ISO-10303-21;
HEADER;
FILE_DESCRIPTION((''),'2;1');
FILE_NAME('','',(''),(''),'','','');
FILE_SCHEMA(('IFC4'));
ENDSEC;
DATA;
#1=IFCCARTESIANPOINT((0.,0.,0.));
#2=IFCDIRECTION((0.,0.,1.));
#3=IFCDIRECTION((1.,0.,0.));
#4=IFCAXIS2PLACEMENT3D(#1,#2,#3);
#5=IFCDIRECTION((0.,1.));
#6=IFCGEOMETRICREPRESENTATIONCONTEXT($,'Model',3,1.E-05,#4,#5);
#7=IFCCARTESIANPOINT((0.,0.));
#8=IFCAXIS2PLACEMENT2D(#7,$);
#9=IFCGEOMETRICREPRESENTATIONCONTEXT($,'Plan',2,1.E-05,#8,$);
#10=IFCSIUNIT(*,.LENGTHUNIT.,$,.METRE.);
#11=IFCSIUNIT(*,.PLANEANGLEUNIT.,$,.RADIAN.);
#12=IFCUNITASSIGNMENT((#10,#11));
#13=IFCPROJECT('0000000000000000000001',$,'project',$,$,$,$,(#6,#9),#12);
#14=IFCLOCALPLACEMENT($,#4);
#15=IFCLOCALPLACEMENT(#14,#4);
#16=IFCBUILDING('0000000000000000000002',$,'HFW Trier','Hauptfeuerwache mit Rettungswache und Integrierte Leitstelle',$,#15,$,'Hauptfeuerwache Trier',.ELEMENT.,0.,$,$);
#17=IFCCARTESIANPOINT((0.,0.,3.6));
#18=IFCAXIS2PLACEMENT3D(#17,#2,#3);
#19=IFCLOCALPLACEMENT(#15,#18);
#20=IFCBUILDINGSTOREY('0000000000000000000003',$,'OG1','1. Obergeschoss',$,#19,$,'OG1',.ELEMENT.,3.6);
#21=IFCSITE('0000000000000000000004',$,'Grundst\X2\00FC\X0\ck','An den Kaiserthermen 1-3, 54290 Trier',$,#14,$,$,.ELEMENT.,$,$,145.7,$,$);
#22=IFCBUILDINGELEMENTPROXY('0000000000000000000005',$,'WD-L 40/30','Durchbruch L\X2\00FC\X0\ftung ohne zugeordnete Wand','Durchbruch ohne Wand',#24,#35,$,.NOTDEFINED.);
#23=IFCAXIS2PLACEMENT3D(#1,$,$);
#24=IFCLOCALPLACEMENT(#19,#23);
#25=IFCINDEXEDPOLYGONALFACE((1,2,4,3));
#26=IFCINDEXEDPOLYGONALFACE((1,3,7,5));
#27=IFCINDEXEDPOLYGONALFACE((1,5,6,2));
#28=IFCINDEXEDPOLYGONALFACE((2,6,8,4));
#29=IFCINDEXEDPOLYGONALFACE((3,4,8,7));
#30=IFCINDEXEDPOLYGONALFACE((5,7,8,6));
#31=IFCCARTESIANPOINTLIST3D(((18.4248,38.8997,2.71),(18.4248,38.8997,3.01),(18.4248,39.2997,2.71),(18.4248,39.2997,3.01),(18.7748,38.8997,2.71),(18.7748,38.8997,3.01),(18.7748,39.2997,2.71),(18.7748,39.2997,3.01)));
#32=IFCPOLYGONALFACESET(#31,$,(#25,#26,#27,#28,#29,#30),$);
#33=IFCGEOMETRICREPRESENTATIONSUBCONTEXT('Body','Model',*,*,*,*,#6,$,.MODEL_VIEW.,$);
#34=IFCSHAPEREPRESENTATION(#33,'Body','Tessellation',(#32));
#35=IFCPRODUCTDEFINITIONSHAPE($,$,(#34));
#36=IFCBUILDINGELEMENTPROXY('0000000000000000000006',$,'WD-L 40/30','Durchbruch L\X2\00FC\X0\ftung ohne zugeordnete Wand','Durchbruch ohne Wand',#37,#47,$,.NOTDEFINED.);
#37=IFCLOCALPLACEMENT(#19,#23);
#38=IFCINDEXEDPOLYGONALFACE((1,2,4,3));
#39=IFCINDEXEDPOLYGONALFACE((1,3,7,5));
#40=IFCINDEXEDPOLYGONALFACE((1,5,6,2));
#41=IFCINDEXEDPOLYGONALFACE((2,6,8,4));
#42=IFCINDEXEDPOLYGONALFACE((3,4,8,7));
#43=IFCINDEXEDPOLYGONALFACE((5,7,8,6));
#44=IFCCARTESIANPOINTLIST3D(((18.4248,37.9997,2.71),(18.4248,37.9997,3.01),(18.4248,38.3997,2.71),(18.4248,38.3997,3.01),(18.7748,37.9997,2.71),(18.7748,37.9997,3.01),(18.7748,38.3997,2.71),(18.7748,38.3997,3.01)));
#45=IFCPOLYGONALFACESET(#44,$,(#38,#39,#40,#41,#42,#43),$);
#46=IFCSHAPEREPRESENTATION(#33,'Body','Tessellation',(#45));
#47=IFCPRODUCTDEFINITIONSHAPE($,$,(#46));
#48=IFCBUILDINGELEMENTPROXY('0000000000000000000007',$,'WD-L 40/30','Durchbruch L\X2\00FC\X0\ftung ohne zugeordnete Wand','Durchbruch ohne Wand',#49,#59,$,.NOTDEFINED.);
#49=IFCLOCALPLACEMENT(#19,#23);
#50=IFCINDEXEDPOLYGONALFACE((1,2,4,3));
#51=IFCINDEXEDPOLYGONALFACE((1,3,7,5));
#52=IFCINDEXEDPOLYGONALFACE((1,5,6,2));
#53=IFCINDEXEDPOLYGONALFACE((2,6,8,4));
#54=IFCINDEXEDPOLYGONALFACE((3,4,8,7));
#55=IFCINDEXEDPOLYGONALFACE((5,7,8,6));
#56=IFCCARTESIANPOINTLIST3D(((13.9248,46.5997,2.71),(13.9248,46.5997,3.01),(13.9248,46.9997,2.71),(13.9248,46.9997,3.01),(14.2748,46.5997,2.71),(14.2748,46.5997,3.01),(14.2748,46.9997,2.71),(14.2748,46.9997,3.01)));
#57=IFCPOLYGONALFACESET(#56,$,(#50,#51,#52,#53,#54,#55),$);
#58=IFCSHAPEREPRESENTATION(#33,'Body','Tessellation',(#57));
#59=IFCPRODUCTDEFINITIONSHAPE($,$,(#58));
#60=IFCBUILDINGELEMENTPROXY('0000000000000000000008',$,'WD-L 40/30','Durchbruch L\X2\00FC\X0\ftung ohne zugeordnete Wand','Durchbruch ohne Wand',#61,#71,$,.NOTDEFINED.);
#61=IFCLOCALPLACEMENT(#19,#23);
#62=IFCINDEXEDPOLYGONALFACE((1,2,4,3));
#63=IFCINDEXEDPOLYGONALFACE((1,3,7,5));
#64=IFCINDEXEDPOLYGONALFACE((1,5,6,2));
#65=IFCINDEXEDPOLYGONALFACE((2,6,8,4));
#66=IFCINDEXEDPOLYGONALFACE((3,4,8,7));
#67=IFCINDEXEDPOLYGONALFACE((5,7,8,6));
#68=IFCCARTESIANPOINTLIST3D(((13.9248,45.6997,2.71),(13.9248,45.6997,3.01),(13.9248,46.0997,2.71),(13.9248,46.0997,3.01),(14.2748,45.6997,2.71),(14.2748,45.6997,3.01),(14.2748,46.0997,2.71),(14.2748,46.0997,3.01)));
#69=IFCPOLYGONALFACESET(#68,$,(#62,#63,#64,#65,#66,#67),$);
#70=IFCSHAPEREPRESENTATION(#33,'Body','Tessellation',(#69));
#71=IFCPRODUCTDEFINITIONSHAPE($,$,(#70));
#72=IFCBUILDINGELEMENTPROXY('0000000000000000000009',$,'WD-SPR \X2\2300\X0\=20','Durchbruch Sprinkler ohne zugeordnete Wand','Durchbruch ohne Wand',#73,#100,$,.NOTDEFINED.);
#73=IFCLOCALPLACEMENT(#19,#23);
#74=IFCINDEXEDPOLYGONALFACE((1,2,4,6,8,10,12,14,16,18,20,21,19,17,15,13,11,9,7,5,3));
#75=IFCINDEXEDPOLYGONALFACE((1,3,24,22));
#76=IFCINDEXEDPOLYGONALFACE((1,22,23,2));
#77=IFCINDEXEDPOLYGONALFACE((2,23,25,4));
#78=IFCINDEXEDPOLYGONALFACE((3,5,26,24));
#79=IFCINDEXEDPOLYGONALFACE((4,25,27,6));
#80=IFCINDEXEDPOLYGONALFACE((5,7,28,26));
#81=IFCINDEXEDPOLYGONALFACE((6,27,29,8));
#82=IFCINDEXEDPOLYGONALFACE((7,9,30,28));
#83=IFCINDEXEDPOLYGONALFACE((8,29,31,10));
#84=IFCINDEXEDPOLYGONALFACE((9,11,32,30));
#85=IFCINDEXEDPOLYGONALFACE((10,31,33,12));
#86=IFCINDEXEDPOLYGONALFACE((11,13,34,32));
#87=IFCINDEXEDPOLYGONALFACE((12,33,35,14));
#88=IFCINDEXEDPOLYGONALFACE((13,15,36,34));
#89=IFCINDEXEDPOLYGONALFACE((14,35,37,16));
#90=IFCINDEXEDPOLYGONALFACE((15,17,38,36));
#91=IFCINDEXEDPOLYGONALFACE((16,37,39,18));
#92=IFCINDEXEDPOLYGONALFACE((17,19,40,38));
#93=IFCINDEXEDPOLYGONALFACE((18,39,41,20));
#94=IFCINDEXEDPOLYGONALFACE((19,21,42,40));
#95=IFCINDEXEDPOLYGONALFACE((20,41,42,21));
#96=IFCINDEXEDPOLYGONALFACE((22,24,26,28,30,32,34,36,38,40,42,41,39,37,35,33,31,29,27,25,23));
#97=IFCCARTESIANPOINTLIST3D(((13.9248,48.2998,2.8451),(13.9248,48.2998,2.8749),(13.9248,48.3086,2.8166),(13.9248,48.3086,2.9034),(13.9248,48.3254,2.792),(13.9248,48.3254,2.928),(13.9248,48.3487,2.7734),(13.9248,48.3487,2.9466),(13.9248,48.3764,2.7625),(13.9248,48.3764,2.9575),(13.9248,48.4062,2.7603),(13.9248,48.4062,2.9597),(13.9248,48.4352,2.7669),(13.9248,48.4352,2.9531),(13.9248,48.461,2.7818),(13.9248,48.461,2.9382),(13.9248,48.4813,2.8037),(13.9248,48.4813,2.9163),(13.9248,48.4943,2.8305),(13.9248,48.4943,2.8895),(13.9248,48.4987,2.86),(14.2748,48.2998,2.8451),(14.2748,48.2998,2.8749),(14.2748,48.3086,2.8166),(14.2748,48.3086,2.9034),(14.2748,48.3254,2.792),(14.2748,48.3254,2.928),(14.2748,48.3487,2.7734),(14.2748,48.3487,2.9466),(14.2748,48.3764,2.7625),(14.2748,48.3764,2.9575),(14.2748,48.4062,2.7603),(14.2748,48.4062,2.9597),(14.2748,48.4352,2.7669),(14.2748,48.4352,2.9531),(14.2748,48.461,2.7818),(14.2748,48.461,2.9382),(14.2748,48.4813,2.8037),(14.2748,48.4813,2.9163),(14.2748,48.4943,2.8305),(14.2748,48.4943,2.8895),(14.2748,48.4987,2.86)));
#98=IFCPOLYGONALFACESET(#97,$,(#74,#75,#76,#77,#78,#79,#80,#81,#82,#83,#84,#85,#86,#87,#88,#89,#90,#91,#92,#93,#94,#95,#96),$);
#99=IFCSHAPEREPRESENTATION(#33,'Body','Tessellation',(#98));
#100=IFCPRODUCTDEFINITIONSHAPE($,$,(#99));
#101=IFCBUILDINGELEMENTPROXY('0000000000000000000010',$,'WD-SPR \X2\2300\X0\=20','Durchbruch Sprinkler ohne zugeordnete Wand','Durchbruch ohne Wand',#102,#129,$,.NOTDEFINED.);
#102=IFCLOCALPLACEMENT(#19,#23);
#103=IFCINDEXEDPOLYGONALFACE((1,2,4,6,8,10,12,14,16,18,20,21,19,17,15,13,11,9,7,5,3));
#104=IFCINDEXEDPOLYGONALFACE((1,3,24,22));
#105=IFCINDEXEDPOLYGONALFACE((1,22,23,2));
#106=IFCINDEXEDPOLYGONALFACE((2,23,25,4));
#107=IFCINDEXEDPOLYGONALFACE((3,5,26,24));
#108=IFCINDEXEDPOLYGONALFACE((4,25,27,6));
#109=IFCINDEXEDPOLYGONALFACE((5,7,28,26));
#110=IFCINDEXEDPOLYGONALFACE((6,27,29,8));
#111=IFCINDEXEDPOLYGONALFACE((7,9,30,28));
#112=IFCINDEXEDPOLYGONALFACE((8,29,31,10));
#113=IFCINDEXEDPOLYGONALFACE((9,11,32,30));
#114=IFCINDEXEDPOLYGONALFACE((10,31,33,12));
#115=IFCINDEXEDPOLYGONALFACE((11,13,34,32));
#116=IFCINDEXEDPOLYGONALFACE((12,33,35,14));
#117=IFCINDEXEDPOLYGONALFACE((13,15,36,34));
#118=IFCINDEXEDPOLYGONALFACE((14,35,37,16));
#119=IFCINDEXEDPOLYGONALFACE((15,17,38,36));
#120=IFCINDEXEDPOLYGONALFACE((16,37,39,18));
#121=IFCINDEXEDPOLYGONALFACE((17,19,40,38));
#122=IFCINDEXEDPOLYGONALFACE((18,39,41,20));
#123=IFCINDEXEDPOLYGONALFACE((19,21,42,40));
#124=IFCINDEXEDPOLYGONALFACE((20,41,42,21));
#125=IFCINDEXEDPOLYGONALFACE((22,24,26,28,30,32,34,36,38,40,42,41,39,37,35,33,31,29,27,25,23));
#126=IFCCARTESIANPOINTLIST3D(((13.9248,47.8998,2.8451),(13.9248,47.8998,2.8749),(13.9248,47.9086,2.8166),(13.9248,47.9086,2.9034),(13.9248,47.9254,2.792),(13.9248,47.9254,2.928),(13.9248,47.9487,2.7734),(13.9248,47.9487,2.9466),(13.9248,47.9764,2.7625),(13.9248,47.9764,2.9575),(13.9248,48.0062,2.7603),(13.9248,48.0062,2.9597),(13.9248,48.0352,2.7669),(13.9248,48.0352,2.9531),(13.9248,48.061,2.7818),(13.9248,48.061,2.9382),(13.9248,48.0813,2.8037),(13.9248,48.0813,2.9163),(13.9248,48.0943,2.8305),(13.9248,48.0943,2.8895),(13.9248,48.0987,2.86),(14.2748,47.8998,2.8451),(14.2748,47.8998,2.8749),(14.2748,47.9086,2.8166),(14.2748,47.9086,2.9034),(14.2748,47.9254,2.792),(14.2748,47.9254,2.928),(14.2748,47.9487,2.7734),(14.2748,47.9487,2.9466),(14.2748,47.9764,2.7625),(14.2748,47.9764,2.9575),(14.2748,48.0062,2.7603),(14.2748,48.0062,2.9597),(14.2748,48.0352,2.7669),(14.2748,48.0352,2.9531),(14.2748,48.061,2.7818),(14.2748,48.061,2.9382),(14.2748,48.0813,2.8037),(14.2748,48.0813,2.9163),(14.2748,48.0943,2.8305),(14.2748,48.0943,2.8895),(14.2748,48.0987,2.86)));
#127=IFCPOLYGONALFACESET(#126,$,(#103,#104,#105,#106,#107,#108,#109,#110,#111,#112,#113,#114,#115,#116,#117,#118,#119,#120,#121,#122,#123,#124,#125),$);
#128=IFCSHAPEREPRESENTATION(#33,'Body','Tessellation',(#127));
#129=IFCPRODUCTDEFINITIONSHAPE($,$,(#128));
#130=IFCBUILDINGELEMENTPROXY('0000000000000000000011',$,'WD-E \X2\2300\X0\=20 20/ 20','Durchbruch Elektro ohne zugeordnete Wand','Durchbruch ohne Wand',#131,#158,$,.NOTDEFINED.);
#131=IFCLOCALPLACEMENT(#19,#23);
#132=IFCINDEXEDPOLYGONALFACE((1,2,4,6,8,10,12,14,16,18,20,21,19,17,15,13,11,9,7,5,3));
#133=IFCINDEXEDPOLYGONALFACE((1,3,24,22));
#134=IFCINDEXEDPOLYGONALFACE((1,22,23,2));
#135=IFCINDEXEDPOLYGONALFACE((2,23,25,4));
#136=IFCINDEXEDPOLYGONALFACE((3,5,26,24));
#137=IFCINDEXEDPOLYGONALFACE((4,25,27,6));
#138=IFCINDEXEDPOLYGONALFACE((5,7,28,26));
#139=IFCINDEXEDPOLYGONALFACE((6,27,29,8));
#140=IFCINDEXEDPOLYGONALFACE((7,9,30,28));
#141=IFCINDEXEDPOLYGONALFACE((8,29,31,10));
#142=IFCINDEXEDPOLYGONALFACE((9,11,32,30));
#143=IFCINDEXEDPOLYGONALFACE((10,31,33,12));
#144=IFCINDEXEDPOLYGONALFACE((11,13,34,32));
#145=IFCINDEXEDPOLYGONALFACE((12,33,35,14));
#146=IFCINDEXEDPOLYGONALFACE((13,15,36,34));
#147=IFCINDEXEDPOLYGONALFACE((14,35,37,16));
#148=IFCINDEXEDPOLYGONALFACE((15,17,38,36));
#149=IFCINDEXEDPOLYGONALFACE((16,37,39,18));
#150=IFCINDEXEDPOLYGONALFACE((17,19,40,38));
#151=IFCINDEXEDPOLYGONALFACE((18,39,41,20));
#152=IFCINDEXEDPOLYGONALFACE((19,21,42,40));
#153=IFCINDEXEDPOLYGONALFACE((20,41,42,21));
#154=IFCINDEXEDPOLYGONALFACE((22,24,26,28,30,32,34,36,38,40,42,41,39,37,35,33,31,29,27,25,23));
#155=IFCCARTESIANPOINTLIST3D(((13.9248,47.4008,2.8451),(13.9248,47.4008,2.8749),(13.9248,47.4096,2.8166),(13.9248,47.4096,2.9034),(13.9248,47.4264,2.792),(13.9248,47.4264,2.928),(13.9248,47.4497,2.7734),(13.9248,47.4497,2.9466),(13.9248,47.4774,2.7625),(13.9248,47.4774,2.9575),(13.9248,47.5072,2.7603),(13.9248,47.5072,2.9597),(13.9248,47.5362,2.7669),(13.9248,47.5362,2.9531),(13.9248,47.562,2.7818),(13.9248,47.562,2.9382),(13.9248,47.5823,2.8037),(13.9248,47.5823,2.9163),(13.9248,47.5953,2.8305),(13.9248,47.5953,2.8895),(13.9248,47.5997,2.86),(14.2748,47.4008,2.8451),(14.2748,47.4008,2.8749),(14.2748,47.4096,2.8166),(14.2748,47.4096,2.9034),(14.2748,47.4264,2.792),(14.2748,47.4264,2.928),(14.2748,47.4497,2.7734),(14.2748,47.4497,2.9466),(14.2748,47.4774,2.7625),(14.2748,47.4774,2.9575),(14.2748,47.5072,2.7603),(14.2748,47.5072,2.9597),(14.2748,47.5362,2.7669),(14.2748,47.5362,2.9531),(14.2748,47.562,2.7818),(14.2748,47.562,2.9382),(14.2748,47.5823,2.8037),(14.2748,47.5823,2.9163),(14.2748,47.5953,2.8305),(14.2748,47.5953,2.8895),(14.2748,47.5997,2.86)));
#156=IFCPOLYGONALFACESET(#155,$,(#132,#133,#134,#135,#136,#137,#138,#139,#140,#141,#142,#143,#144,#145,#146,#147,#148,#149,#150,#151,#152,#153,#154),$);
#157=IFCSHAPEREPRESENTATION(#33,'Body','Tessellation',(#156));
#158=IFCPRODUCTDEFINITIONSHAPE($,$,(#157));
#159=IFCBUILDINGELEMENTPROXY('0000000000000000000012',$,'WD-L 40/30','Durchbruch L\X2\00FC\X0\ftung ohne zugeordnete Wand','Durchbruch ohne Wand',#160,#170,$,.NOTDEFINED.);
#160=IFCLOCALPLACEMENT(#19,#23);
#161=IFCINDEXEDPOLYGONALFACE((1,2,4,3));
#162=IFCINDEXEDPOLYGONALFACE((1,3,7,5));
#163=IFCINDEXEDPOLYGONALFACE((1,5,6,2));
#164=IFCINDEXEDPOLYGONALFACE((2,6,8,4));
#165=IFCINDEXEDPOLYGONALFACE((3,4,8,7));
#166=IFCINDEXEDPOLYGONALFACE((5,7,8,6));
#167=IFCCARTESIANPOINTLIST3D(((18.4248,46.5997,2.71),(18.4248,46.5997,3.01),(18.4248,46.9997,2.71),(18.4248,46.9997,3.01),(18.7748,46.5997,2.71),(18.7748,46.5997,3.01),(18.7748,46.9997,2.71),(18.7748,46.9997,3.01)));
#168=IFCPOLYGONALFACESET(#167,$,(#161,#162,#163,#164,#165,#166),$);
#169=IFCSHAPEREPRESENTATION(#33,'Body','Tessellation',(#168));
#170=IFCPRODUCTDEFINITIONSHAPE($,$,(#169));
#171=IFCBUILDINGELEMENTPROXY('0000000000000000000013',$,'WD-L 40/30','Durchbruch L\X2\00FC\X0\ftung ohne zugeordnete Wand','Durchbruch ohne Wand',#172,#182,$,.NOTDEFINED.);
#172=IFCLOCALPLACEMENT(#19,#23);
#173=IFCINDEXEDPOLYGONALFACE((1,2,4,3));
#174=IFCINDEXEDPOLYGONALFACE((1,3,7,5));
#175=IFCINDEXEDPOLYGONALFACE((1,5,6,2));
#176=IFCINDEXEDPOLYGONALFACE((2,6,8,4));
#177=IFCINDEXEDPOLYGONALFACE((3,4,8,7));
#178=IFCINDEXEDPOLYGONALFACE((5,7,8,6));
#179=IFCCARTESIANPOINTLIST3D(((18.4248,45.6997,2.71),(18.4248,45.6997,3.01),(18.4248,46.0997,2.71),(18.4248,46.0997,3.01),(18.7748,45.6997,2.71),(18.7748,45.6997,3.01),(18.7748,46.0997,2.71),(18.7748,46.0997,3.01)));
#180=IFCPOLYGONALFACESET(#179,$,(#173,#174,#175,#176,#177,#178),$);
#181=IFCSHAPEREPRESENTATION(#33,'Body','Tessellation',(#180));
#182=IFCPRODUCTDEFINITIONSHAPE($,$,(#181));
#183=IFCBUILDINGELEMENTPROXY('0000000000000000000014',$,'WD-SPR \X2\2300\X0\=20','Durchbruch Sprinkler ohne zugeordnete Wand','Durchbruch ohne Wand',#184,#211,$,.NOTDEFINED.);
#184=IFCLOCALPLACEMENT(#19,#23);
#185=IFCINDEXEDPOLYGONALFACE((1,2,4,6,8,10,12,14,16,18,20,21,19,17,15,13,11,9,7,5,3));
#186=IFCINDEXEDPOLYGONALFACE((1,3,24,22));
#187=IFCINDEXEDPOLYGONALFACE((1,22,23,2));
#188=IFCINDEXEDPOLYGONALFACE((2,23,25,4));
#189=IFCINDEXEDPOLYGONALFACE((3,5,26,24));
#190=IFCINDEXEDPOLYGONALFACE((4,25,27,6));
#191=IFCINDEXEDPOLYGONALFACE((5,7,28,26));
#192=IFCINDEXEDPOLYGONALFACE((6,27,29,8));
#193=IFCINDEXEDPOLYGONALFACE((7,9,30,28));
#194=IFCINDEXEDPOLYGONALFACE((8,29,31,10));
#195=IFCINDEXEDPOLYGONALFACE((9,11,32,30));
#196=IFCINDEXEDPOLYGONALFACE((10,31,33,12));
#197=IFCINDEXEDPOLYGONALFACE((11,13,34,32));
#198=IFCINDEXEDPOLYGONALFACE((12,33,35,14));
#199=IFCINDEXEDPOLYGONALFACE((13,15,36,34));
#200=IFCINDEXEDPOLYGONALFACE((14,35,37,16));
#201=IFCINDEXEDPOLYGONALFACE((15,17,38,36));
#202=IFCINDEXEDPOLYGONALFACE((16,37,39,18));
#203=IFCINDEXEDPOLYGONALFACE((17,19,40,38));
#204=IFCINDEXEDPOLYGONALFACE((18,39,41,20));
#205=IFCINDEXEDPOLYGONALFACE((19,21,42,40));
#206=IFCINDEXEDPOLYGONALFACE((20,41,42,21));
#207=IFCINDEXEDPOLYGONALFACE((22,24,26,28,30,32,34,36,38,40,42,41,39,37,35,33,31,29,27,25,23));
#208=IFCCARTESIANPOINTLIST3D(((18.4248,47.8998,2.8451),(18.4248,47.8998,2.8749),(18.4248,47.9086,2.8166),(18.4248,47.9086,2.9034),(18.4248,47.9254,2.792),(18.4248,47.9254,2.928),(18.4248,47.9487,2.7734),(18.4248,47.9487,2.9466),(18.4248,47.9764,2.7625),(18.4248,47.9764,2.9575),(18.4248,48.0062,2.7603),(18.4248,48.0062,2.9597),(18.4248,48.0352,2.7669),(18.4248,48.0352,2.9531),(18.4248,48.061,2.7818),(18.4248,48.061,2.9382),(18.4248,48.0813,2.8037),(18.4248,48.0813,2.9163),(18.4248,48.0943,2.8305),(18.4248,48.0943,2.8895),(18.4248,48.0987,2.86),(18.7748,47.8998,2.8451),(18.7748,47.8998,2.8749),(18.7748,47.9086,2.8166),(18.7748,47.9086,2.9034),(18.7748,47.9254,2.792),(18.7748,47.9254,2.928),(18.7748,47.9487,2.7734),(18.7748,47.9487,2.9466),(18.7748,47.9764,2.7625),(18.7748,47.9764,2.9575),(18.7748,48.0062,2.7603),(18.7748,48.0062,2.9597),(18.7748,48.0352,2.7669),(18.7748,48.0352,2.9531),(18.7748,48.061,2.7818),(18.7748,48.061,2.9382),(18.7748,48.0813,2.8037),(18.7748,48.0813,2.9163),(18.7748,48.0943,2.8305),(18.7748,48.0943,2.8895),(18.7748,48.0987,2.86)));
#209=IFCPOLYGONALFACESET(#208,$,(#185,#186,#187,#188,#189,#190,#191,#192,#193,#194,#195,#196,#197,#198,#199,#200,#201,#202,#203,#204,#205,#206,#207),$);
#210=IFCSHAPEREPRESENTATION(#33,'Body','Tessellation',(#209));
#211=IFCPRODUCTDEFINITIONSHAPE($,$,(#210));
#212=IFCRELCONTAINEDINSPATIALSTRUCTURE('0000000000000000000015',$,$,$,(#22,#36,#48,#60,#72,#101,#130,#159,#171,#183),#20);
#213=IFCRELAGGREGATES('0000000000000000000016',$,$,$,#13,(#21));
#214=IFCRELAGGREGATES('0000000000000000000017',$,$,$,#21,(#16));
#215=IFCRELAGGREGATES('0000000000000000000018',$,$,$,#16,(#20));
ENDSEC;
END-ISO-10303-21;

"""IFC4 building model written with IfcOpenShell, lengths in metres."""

from ifc_helpers import new_model, si_unit, direction, frame, origin_with_axes, origin_2d, place, context, subcontext, project, spatial, rectangle, circle, extrude, element, save


model = new_model("IFC4")

# Units and contexts
model_context = context("Model", 3, precision=1e-05, world=origin_with_axes(), true_north=direction((0.0, 1.0)))
plan_context = context("Plan", 2, precision=1e-05, world=origin_2d())
body_context = subcontext(model_context, "Body", "Model", "MODEL_VIEW")
ifc_project = project(units=[si_unit("LENGTHUNIT", "METRE"), si_unit("PLANEANGLEUNIT", "RADIAN")], contexts=[model_context, plan_context])

# Site, building, storey
site_placement = place(None, origin_with_axes())
site = spatial("IfcSite", under=ifc_project, at=site_placement, Name="Grundstück", Description="An den Kaiserthermen 1-3, 54290 Trier", CompositionType="ELEMENT", RefElevation=145.7)
building_placement = place(site_placement, origin_with_axes())
building = spatial("IfcBuilding", under=site, at=building_placement, Name="HFW Trier", Description="Hauptfeuerwache mit Rettungswache und Integrierte Leitstelle", LongName="Hauptfeuerwache Trier", CompositionType="ELEMENT", ElevationOfRefHeight=0.0)
storey_placement = place(building_placement, frame((0.0, 0.0, 3.6), z_axis=(0.0, 0.0, 1.0), x_axis=(1.0, 0.0, 0.0)))
storey = spatial("IfcBuildingStorey", under=building, at=storey_placement, Name="OG1", Description="1. Obergeschoss", LongName="OG1", CompositionType="ELEMENT", Elevation=3.6)

# Building element proxies
for number, where, z_axis, x_axis, name in (
    (1, (18.5998, 39.0997, 2.71), (0.0, 0.0, 1.0), (0.0, 1.0, 0.0), "WD-L 40/30"),
    (2, (18.5998, 38.1997, 2.71), (0.0, 0.0, 1.0), (0.0, 1.0, 0.0), "WD-L 40/30"),
    (3, (14.0998, 46.7997, 2.71), (0.0, 0.0, 1.0), (0.0, 1.0, 0.0), "WD-L 40/30"),
    (4, (14.0998, 45.8997, 2.71), (0.0, 0.0, 1.0), (0.0, 1.0, 0.0), "WD-L 40/30"),
):
    element("IfcBuildingElementProxy", number, at=place(storey_placement, frame(where, z_axis=z_axis, x_axis=x_axis)), inside=storey, Name=name, Description="Durchbruch Lüftung ohne zugeordnete Wand", ObjectType="Durchbruch ohne Wand", PredefinedType="NOTDEFINED", context=body_context, shape_type="SweptSolid", body=[
        extrude(rectangle(XDim=0.4, YDim=0.35, at=origin_2d()), origin_with_axes(), (0.0, 0.0, 1.0), 0.3),
    ])
for number, where, z_axis, x_axis, name, description in (
    (5, (14.0998, 48.3987, 2.76), (0.0, 0.0, 1.0), (0.0, 1.0, 0.0), "WD-SPR ⌀=20", "Durchbruch Sprinkler ohne zugeordnete Wand"),
    (6, (14.0998, 47.9987, 2.76), (0.0, 0.0, 1.0), (0.0, 1.0, 0.0), "WD-SPR ⌀=20", "Durchbruch Sprinkler ohne zugeordnete Wand"),
    (7, (14.0998, 47.4997, 2.76), (0.0, 0.0, 1.0), (0.0, 1.0, 0.0), "WD-E ⌀=20 20/ 20", "Durchbruch Elektro ohne zugeordnete Wand"),
):
    element("IfcBuildingElementProxy", number, at=place(storey_placement, frame(where, z_axis=z_axis, x_axis=x_axis)), inside=storey, Name=name, Description=description, ObjectType="Durchbruch ohne Wand", PredefinedType="NOTDEFINED", context=body_context, shape_type="SweptSolid", body=[
        extrude(circle(Radius=0.1, at=origin_2d()), frame((0.0, -0.175, 0.1), z_axis=(0.0, 1.0, 0.0), x_axis=(1.0, 0.0, 0.0)), (0.0, 0.0, 1.0), 0.35),
    ])
for number, where, z_axis, x_axis, name in (
    (8, (18.5998, 46.7997, 2.71), (0.0, 0.0, 1.0), (0.0, 1.0, 0.0), "WD-L 40/30"),
    (9, (18.5998, 45.8997, 2.71), (0.0, 0.0, 1.0), (0.0, 1.0, 0.0), "WD-L 40/30"),
):
    element("IfcBuildingElementProxy", number, at=place(storey_placement, frame(where, z_axis=z_axis, x_axis=x_axis)), inside=storey, Name=name, Description="Durchbruch Lüftung ohne zugeordnete Wand", ObjectType="Durchbruch ohne Wand", PredefinedType="NOTDEFINED", context=body_context, shape_type="SweptSolid", body=[
        extrude(rectangle(XDim=0.4, YDim=0.35, at=origin_2d()), origin_with_axes(), (0.0, 0.0, 1.0), 0.3),
    ])
for number, where, z_axis, x_axis, name in (
    (10, (18.5998, 47.9987, 2.76), (0.0, 0.0, 1.0), (0.0, 1.0, 0.0), "WD-SPR ⌀=20"),
):
    element("IfcBuildingElementProxy", number, at=place(storey_placement, frame(where, z_axis=z_axis, x_axis=x_axis)), inside=storey, Name=name, Description="Durchbruch Sprinkler ohne zugeordnete Wand", ObjectType="Durchbruch ohne Wand", PredefinedType="NOTDEFINED", context=body_context, shape_type="SweptSolid", body=[
        extrude(circle(Radius=0.1, at=origin_2d()), frame((0.0, -0.175, 0.1), z_axis=(0.0, 1.0, 0.0), x_axis=(1.0, 0.0, 0.0)), (0.0, 0.0, 1.0), 0.35),
    ])

save(model, "model.ifc")
